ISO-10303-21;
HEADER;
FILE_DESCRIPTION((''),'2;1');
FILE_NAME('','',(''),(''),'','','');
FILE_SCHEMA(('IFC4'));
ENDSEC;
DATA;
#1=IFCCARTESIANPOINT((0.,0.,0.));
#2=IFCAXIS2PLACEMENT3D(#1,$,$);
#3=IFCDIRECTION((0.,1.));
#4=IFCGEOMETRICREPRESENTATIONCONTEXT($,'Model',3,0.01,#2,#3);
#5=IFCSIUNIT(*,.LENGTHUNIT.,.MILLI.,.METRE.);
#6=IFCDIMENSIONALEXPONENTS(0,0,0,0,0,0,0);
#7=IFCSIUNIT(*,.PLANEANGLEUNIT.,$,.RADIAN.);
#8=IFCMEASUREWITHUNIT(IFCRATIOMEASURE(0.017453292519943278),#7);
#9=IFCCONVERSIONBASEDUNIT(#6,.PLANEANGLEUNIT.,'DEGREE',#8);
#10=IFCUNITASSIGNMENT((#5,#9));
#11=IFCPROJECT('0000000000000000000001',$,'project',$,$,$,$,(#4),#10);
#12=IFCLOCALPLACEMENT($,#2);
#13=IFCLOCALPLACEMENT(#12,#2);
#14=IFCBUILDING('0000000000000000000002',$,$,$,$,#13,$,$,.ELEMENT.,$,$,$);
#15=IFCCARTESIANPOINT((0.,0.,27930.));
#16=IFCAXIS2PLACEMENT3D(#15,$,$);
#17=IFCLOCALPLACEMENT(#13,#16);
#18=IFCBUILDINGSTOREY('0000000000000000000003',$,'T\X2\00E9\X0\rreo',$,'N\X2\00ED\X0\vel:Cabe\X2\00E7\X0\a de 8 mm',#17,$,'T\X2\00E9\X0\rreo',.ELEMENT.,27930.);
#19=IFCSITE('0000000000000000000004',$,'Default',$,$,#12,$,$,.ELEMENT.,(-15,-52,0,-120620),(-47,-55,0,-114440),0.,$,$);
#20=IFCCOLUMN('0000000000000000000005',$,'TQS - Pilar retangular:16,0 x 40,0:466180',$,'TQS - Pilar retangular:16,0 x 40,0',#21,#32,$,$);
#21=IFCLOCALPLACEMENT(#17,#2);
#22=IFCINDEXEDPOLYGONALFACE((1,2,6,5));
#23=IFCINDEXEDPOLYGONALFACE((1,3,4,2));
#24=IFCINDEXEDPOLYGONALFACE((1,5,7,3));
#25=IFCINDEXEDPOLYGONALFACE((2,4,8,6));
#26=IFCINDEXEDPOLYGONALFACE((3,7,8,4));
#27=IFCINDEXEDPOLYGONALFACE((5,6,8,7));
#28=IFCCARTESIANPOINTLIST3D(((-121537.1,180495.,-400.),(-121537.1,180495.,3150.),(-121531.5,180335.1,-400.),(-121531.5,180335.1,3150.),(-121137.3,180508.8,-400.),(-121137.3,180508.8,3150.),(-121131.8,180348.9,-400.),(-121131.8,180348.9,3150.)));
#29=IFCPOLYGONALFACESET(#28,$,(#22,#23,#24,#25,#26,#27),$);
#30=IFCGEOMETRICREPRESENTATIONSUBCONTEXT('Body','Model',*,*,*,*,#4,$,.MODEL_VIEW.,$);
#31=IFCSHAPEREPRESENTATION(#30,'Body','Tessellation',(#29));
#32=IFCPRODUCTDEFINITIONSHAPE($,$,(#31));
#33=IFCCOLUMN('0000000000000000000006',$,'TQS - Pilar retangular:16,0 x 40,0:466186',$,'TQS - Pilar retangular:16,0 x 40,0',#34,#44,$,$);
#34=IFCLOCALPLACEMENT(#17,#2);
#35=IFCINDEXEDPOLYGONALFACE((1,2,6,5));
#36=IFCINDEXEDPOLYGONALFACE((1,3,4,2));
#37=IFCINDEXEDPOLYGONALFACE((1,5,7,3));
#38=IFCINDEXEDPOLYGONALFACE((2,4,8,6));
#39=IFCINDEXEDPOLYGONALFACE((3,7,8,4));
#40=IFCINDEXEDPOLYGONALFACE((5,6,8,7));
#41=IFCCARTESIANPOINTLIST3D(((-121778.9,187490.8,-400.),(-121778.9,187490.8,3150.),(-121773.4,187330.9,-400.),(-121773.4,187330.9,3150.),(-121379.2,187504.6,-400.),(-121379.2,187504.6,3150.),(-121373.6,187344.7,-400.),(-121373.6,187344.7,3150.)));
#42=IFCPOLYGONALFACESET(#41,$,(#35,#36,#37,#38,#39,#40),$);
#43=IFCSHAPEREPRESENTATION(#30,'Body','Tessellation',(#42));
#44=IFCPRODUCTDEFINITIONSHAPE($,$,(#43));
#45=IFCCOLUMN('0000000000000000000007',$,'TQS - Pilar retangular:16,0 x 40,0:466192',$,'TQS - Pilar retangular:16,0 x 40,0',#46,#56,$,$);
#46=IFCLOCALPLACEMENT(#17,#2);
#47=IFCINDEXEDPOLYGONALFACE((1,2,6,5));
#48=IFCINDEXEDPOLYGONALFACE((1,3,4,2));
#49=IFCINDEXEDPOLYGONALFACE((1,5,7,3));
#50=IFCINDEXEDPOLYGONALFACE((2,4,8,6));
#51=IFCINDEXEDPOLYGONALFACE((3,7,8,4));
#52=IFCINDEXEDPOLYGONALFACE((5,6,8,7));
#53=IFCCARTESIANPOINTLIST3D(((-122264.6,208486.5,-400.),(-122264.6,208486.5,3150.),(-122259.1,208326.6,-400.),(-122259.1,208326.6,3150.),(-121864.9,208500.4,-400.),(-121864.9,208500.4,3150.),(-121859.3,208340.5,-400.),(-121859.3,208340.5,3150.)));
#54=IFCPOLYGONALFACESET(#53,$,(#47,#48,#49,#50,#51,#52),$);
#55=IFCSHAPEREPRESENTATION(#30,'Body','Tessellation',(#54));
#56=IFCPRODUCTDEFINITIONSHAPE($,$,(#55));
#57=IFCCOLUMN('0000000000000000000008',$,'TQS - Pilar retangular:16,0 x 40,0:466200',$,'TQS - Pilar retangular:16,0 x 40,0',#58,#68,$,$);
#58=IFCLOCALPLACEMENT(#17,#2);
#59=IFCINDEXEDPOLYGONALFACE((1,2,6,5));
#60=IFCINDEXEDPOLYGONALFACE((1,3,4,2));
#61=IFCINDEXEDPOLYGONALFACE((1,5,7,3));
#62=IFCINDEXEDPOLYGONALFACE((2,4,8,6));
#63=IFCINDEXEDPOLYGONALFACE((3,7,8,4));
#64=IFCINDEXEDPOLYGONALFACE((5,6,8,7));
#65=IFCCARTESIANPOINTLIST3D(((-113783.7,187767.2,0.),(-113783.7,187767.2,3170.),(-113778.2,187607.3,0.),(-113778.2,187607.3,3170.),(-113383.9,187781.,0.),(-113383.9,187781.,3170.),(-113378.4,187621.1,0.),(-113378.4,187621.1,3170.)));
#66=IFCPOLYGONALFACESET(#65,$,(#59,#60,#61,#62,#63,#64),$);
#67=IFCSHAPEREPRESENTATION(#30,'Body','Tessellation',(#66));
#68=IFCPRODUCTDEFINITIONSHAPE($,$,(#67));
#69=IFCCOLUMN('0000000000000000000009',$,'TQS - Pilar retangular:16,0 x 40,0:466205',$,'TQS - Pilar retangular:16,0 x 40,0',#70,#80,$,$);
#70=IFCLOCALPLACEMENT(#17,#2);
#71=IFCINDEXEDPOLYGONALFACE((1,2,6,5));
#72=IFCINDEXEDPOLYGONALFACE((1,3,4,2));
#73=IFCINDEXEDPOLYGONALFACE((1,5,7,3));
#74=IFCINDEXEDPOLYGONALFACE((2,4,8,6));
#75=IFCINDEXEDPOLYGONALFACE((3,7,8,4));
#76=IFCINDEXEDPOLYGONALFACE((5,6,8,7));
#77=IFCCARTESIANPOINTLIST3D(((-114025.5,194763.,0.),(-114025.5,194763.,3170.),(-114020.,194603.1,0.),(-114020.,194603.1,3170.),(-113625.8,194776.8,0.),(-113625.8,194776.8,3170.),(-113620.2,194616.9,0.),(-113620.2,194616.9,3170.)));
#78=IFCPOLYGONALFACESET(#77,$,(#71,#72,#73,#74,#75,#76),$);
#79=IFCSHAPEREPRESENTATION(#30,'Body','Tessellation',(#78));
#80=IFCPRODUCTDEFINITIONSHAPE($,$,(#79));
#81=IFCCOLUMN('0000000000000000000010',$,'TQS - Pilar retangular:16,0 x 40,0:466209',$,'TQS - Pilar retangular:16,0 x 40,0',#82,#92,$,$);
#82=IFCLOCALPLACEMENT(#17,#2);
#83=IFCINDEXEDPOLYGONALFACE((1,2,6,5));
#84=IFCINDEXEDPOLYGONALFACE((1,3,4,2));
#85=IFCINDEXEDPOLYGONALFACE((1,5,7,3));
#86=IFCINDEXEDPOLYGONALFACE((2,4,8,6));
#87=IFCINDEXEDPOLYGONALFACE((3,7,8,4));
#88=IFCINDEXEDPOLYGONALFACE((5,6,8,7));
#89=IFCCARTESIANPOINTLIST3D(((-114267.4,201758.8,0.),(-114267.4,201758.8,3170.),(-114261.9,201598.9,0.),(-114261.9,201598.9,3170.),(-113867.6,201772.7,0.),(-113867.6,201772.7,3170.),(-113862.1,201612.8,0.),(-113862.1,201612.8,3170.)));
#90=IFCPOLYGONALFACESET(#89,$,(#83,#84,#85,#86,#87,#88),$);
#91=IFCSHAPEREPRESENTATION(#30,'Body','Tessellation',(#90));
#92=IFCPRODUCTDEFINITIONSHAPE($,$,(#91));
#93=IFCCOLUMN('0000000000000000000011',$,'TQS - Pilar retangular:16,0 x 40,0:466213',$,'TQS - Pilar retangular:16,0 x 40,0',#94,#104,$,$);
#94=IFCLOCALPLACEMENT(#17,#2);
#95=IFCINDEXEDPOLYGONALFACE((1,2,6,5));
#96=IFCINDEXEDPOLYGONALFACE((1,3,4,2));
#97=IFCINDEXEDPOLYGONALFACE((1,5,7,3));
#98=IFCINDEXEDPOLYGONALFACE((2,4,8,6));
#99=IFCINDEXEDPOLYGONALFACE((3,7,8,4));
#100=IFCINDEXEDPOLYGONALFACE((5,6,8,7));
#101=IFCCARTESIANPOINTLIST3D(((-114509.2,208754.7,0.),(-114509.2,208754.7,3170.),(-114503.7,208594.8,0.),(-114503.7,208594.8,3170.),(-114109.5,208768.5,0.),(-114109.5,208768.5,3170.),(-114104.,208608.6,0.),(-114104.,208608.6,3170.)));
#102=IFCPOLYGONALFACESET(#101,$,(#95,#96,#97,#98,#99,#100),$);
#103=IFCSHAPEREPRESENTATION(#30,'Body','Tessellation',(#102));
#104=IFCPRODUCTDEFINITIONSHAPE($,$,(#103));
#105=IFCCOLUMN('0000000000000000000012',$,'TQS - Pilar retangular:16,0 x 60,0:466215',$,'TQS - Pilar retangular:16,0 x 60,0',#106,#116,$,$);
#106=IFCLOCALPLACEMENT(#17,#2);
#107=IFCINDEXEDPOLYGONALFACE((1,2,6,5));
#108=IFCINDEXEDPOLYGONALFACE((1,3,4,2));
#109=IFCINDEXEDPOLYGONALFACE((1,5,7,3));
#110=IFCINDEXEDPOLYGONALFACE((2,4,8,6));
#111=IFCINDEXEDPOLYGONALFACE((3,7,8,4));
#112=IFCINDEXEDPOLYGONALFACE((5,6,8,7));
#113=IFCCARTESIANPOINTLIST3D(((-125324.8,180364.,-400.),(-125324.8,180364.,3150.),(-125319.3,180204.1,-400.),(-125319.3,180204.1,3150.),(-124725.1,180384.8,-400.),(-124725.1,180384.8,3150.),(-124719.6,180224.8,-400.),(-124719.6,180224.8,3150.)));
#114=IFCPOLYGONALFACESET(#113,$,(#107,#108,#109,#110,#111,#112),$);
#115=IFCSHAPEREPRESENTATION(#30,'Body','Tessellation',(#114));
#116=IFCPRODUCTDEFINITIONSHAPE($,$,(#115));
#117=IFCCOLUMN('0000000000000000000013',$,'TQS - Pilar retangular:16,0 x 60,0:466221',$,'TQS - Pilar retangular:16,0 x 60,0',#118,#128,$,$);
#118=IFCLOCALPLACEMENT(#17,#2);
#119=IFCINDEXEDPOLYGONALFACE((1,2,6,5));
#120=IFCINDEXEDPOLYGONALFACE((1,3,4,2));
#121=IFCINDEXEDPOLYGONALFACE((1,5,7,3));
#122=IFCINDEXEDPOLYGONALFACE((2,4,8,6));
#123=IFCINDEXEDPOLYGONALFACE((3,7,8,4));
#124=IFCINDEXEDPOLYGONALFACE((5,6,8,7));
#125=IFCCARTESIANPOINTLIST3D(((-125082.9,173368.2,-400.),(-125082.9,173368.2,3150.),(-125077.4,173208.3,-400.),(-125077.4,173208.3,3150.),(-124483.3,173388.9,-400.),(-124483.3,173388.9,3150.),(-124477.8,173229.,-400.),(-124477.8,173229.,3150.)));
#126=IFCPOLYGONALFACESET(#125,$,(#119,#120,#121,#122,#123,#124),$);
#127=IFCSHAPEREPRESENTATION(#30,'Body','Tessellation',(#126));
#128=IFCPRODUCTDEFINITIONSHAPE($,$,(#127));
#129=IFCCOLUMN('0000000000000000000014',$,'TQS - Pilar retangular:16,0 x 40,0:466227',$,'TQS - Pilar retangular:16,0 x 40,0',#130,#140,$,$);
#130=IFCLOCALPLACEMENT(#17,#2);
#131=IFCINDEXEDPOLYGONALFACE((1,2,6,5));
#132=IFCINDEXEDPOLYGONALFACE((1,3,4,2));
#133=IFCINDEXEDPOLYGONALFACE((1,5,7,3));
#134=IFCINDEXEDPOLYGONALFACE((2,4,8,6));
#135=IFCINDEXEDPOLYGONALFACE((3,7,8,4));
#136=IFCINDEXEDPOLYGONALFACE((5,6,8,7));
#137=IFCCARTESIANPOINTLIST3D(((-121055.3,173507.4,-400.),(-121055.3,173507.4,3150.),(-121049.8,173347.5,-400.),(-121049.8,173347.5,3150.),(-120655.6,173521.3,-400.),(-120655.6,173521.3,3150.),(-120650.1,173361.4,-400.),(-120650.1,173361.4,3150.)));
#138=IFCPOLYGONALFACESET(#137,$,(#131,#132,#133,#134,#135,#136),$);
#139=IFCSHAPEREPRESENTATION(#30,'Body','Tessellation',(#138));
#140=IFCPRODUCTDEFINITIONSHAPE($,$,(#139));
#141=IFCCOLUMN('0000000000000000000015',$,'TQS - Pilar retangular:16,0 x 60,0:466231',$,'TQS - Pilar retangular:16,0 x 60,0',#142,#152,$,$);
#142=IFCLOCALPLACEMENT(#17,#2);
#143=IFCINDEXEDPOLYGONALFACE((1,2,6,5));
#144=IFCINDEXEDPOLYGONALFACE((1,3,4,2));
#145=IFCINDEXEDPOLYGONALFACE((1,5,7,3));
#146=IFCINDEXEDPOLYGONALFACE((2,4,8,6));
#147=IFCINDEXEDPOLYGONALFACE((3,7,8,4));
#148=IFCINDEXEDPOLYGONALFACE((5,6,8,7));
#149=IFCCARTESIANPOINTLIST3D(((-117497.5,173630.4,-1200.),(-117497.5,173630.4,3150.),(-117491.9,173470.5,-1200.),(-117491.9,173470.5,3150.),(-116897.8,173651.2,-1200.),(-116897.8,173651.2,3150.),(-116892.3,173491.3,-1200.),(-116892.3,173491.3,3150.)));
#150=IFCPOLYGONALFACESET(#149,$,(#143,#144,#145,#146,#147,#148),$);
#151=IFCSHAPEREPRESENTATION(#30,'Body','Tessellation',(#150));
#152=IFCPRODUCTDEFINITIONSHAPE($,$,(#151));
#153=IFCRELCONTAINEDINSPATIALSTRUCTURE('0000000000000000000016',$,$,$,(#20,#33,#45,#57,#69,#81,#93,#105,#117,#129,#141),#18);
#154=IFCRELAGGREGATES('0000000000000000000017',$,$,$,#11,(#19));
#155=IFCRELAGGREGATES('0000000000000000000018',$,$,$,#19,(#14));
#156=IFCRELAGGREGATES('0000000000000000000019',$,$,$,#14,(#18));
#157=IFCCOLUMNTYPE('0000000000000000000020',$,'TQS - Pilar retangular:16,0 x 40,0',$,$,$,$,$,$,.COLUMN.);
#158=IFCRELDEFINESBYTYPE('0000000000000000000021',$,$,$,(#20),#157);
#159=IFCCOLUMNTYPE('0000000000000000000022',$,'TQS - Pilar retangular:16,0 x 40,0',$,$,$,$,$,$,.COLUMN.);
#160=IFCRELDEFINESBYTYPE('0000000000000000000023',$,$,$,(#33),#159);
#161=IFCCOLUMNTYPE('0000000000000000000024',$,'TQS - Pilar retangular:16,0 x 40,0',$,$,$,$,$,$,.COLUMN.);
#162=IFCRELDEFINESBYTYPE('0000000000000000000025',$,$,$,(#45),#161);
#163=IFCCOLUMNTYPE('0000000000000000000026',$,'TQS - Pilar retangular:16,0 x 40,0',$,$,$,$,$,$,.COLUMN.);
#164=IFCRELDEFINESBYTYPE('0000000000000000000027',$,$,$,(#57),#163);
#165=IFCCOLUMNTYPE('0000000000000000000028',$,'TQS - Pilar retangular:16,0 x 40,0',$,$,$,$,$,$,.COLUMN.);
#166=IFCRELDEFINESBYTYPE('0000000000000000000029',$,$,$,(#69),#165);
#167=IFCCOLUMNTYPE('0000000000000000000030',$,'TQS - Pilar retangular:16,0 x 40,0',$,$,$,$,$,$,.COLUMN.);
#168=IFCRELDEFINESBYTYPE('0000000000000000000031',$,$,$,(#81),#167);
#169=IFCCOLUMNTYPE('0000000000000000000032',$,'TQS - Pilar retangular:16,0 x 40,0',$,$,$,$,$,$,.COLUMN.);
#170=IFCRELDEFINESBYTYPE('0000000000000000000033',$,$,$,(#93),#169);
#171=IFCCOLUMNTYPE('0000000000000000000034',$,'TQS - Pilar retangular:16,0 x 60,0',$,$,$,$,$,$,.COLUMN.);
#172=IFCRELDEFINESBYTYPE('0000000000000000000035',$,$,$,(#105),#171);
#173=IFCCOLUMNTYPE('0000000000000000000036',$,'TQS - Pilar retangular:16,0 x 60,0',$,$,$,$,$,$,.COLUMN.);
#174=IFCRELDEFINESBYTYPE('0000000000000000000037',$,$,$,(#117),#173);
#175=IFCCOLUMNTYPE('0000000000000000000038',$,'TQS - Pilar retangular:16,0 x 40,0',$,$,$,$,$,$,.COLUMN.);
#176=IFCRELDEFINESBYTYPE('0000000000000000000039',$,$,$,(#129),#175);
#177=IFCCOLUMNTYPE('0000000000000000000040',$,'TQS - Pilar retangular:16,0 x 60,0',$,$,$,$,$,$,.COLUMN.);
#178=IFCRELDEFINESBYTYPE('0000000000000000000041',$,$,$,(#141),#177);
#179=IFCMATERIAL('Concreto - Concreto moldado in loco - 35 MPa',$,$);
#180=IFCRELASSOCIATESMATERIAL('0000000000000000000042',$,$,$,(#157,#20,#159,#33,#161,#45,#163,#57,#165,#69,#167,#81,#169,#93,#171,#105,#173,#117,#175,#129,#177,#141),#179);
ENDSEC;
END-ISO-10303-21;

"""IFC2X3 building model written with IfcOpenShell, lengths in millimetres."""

from ifc_helpers import new_model, entity, si_unit, converted_unit, direction, frame, frame_2d, origin, origin_2d_with_axis, place, context, subcontext, project, spatial, rectangle, extrude, source, transform, mapped, material, type_object, type_shapes, element, save


model = new_model("IFC2X3")

# Units and contexts
model_context = context("Model", 3, precision=0.01, world=origin(), true_north=direction((0.0, 1.0)))
body_context = subcontext(model_context, "Body", "Model", "MODEL_VIEW")
ifc_project = project(units=[si_unit("LENGTHUNIT", "METRE", prefix="MILLI"), converted_unit("PLANEANGLEUNIT", "DEGREE", entity("IfcRatioMeasure", 0.017453292519943278), si_unit("PLANEANGLEUNIT", "RADIAN"), dimensions=[0, 0, 0, 0, 0, 0, 0])], contexts=[model_context])

# Site, building, storey
site_placement = place(None, origin())
site = spatial("IfcSite", under=ifc_project, at=site_placement, Name="Default", CompositionType="ELEMENT", RefLatitude=(-15, -52, 0, -120620), RefLongitude=(-47, -55, 0, -114440), RefElevation=0.0)
building_placement = place(site_placement, origin())
building = spatial("IfcBuilding", under=site, at=building_placement, CompositionType="ELEMENT")
storey_placement = place(building_placement, frame((0.0, 0.0, 27930.0)))
storey = spatial("IfcBuildingStorey", under=building, at=storey_placement, Name="Térreo", ObjectType="Nível:Cabeça de 8 mm", LongName="Térreo", CompositionType="ELEMENT", Elevation=27930.0)

# Columns
ifc_material = material(Name="Concreto - Concreto moldado in loco - 35 MPa")
column_type_1 = type_object("IfcColumnType", Name="TQS - Pilar retangular:16,0 x 40,0", PredefinedType="COLUMN", material=ifc_material)
shared_shape_1 = source(origin(), body_context, "Body", "SweptSolid", [
    extrude(rectangle(XDim=400.0, YDim=160.0, at=origin_2d_with_axis()), frame((-121334.4, 180421.9, 27530.0), z_axis=(0.0, 0.0, 1.0), x_axis=(-0.999403, -0.034551, 0.0)), (0.0, 0.0, 1.0), 3550.0),
])
type_shapes(column_type_1, [shared_shape_1])
column_1_placement = place(storey_placement, frame((0.0, 0.0, -27930.0)))
element("IfcColumn", 1, at=column_1_placement, inside=storey, type_object=column_type_1, material=ifc_material, Name="TQS - Pilar retangular:16,0 x 40,0:466180", ObjectType="TQS - Pilar retangular:16,0 x 40,0", context=body_context, shape_type="MappedRepresentation", body=[
    mapped(shared_shape_1, transform((0.0, 0.0, 0.0), scale=1.0)),
])
column_type_2 = type_object("IfcColumnType", Name="TQS - Pilar retangular:16,0 x 40,0", PredefinedType="COLUMN", material=ifc_material)
shared_shape_2 = source(origin(), body_context, "Body", "SweptSolid", [
    extrude(rectangle(XDim=400.0, YDim=160.0, at=origin_2d_with_axis()), frame((-121576.3, 187417.7, 27530.0), z_axis=(0.0, 0.0, 1.0), x_axis=(-0.999403, -0.034551, 0.0)), (0.0, 0.0, 1.0), 3550.0),
])
type_shapes(column_type_2, [shared_shape_2])
column_2_placement = place(storey_placement, frame((0.0, 0.0, -27930.0)))
element("IfcColumn", 2, at=column_2_placement, inside=storey, type_object=column_type_2, material=ifc_material, Name="TQS - Pilar retangular:16,0 x 40,0:466186", ObjectType="TQS - Pilar retangular:16,0 x 40,0", context=body_context, shape_type="MappedRepresentation", body=[
    mapped(shared_shape_2, transform((0.0, 0.0, 0.0), scale=1.0)),
])
column_type_3 = type_object("IfcColumnType", Name="TQS - Pilar retangular:16,0 x 40,0", PredefinedType="COLUMN", material=ifc_material)
shared_shape_3 = source(origin(), body_context, "Body", "SweptSolid", [
    extrude(rectangle(XDim=400.0, YDim=160.0, at=frame_2d((0.0, 0.0), x_axis=(1.0, 0.0))), frame((-122062.0, 208413.5, 27530.0), z_axis=(0.0, 0.0, 1.0), x_axis=(-0.999403, -0.034551, 0.0)), (0.0, 0.0, 1.0), 3550.0),
])
type_shapes(column_type_3, [shared_shape_3])
column_3_placement = place(storey_placement, frame((0.0, 0.0, -27930.0)))
element("IfcColumn", 3, at=column_3_placement, inside=storey, type_object=column_type_3, material=ifc_material, Name="TQS - Pilar retangular:16,0 x 40,0:466192", ObjectType="TQS - Pilar retangular:16,0 x 40,0", context=body_context, shape_type="MappedRepresentation", body=[
    mapped(shared_shape_3, transform((0.0, 0.0, 0.0), scale=1.0)),
])
column_type_4 = type_object("IfcColumnType", Name="TQS - Pilar retangular:16,0 x 40,0", PredefinedType="COLUMN", material=ifc_material)
shared_shape_4 = source(origin(), body_context, "Body", "SweptSolid", [
    extrude(rectangle(XDim=400.0, YDim=160.0, at=origin_2d_with_axis()), frame((-113581.0, 187694.2, 27930.0), z_axis=(0.0, 0.0, 1.0), x_axis=(-0.999403, -0.034551, 0.0)), (0.0, 0.0, 1.0), 3170.0),
])
type_shapes(column_type_4, [shared_shape_4])
column_4_placement = place(storey_placement, frame((0.0, 0.0, -27930.0)))
element("IfcColumn", 4, at=column_4_placement, inside=storey, type_object=column_type_4, material=ifc_material, Name="TQS - Pilar retangular:16,0 x 40,0:466200", ObjectType="TQS - Pilar retangular:16,0 x 40,0", context=body_context, shape_type="MappedRepresentation", body=[
    mapped(shared_shape_4, transform((0.0, 0.0, 0.0), scale=1.0)),
])
column_type_5 = type_object("IfcColumnType", Name="TQS - Pilar retangular:16,0 x 40,0", PredefinedType="COLUMN", material=ifc_material)
shared_shape_5 = source(origin(), body_context, "Body", "SweptSolid", [
    extrude(rectangle(XDim=400.0, YDim=160.0, at=origin_2d_with_axis()), frame((-113822.9, 194690.0, 27930.0), z_axis=(0.0, 0.0, 1.0), x_axis=(-0.999403, -0.034551, 0.0)), (0.0, 0.0, 1.0), 3170.0),
])
type_shapes(column_type_5, [shared_shape_5])
column_5_placement = place(storey_placement, frame((0.0, 0.0, -27930.0)))
element("IfcColumn", 5, at=column_5_placement, inside=storey, type_object=column_type_5, material=ifc_material, Name="TQS - Pilar retangular:16,0 x 40,0:466205", ObjectType="TQS - Pilar retangular:16,0 x 40,0", context=body_context, shape_type="MappedRepresentation", body=[
    mapped(shared_shape_5, transform((0.0, 0.0, 0.0), scale=1.0)),
])
column_type_6 = type_object("IfcColumnType", Name="TQS - Pilar retangular:16,0 x 40,0", PredefinedType="COLUMN", material=ifc_material)
shared_shape_6 = source(origin(), body_context, "Body", "SweptSolid", [
    extrude(rectangle(XDim=400.0, YDim=160.0, at=origin_2d_with_axis()), frame((-114064.7, 201685.8, 27930.0), z_axis=(0.0, 0.0, 1.0), x_axis=(-0.999403, -0.034551, 0.0)), (0.0, 0.0, 1.0), 3170.0),
])
type_shapes(column_type_6, [shared_shape_6])
column_6_placement = place(storey_placement, frame((0.0, 0.0, -27930.0)))
element("IfcColumn", 6, at=column_6_placement, inside=storey, type_object=column_type_6, material=ifc_material, Name="TQS - Pilar retangular:16,0 x 40,0:466209", ObjectType="TQS - Pilar retangular:16,0 x 40,0", context=body_context, shape_type="MappedRepresentation", body=[
    mapped(shared_shape_6, transform((0.0, 0.0, 0.0), scale=1.0)),
])
column_type_7 = type_object("IfcColumnType", Name="TQS - Pilar retangular:16,0 x 40,0", PredefinedType="COLUMN", material=ifc_material)
shared_shape_7 = source(origin(), body_context, "Body", "SweptSolid", [
    extrude(rectangle(XDim=400.0, YDim=160.0, at=frame_2d((0.0, 0.0), x_axis=(1.0, 0.0))), frame((-114306.6, 208681.6, 27930.0), z_axis=(0.0, 0.0, 1.0), x_axis=(-0.999403, -0.034551, 0.0)), (0.0, 0.0, 1.0), 3170.0),
])
type_shapes(column_type_7, [shared_shape_7])
column_7_placement = place(storey_placement, frame((0.0, 0.0, -27930.0)))
element("IfcColumn", 7, at=column_7_placement, inside=storey, type_object=column_type_7, material=ifc_material, Name="TQS - Pilar retangular:16,0 x 40,0:466213", ObjectType="TQS - Pilar retangular:16,0 x 40,0", context=body_context, shape_type="MappedRepresentation", body=[
    mapped(shared_shape_7, transform((0.0, 0.0, 0.0), scale=1.0)),
])
column_type_8 = type_object("IfcColumnType", Name="TQS - Pilar retangular:16,0 x 60,0", PredefinedType="COLUMN", material=ifc_material)
shared_shape_8 = source(origin(), body_context, "Body", "SweptSolid", [
    extrude(rectangle(XDim=600.0, YDim=160.0, at=origin_2d_with_axis()), frame((-125022.2, 180294.4, 27530.0), z_axis=(0.0, 0.0, 1.0), x_axis=(-0.999403, -0.034551, 0.0)), (0.0, 0.0, 1.0), 3550.0),
])
type_shapes(column_type_8, [shared_shape_8])
column_8_placement = place(storey_placement, frame((0.0, 0.0, -27930.0)))
element("IfcColumn", 8, at=column_8_placement, inside=storey, type_object=column_type_8, material=ifc_material, Name="TQS - Pilar retangular:16,0 x 60,0:466215", ObjectType="TQS - Pilar retangular:16,0 x 60,0", context=body_context, shape_type="MappedRepresentation", body=[
    mapped(shared_shape_8, transform((0.0, 0.0, 0.0), scale=1.0)),
])
column_type_9 = type_object("IfcColumnType", Name="TQS - Pilar retangular:16,0 x 60,0", PredefinedType="COLUMN", material=ifc_material)
shared_shape_9 = source(origin(), body_context, "Body", "SweptSolid", [
    extrude(rectangle(XDim=600.0, YDim=160.0, at=origin_2d_with_axis()), frame((-124780.3, 173298.6, 27530.0), z_axis=(0.0, 0.0, 1.0), x_axis=(-0.999403, -0.034551, 0.0)), (0.0, 0.0, 1.0), 3550.0),
])
type_shapes(column_type_9, [shared_shape_9])
column_9_placement = place(storey_placement, frame((0.0, 0.0, -27930.0)))
element("IfcColumn", 9, at=column_9_placement, inside=storey, type_object=column_type_9, material=ifc_material, Name="TQS - Pilar retangular:16,0 x 60,0:466221", ObjectType="TQS - Pilar retangular:16,0 x 60,0", context=body_context, shape_type="MappedRepresentation", body=[
    mapped(shared_shape_9, transform((0.0, 0.0, 0.0), scale=1.0)),
])
column_type_10 = type_object("IfcColumnType", Name="TQS - Pilar retangular:16,0 x 40,0", PredefinedType="COLUMN", material=ifc_material)
shared_shape_10 = source(origin(), body_context, "Body", "SweptSolid", [
    extrude(rectangle(XDim=400.0, YDim=160.0, at=origin_2d_with_axis()), frame((-120852.7, 173434.4, 27530.0), z_axis=(0.0, 0.0, 1.0), x_axis=(-0.999403, -0.034551, 0.0)), (0.0, 0.0, 1.0), 3550.0),
])
type_shapes(column_type_10, [shared_shape_10])
column_10_placement = place(storey_placement, frame((0.0, 0.0, -27930.0)))
element("IfcColumn", 10, at=column_10_placement, inside=storey, type_object=column_type_10, material=ifc_material, Name="TQS - Pilar retangular:16,0 x 40,0:466227", ObjectType="TQS - Pilar retangular:16,0 x 40,0", context=body_context, shape_type="MappedRepresentation", body=[
    mapped(shared_shape_10, transform((0.0, 0.0, 0.0), scale=1.0)),
])
column_type_11 = type_object("IfcColumnType", Name="TQS - Pilar retangular:16,0 x 60,0", PredefinedType="COLUMN", material=ifc_material)
shared_shape_11 = source(origin(), body_context, "Body", "SweptSolid", [
    extrude(rectangle(XDim=600.0, YDim=160.0, at=origin_2d_with_axis()), frame((-117194.9, 173560.9, 26730.0), z_axis=(0.0, 0.0, 1.0), x_axis=(-0.999403, -0.034551, 0.0)), (0.0, 0.0, 1.0), 4350.0),
])
type_shapes(column_type_11, [shared_shape_11])
column_11_placement = place(storey_placement, frame((0.0, 0.0, -27930.0)))
element("IfcColumn", 11, at=column_11_placement, inside=storey, type_object=column_type_11, material=ifc_material, Name="TQS - Pilar retangular:16,0 x 60,0:466231", ObjectType="TQS - Pilar retangular:16,0 x 60,0", context=body_context, shape_type="MappedRepresentation", body=[
    mapped(shared_shape_11, transform((0.0, 0.0, 0.0), scale=1.0)),
])

save(model, "model.ifc")
